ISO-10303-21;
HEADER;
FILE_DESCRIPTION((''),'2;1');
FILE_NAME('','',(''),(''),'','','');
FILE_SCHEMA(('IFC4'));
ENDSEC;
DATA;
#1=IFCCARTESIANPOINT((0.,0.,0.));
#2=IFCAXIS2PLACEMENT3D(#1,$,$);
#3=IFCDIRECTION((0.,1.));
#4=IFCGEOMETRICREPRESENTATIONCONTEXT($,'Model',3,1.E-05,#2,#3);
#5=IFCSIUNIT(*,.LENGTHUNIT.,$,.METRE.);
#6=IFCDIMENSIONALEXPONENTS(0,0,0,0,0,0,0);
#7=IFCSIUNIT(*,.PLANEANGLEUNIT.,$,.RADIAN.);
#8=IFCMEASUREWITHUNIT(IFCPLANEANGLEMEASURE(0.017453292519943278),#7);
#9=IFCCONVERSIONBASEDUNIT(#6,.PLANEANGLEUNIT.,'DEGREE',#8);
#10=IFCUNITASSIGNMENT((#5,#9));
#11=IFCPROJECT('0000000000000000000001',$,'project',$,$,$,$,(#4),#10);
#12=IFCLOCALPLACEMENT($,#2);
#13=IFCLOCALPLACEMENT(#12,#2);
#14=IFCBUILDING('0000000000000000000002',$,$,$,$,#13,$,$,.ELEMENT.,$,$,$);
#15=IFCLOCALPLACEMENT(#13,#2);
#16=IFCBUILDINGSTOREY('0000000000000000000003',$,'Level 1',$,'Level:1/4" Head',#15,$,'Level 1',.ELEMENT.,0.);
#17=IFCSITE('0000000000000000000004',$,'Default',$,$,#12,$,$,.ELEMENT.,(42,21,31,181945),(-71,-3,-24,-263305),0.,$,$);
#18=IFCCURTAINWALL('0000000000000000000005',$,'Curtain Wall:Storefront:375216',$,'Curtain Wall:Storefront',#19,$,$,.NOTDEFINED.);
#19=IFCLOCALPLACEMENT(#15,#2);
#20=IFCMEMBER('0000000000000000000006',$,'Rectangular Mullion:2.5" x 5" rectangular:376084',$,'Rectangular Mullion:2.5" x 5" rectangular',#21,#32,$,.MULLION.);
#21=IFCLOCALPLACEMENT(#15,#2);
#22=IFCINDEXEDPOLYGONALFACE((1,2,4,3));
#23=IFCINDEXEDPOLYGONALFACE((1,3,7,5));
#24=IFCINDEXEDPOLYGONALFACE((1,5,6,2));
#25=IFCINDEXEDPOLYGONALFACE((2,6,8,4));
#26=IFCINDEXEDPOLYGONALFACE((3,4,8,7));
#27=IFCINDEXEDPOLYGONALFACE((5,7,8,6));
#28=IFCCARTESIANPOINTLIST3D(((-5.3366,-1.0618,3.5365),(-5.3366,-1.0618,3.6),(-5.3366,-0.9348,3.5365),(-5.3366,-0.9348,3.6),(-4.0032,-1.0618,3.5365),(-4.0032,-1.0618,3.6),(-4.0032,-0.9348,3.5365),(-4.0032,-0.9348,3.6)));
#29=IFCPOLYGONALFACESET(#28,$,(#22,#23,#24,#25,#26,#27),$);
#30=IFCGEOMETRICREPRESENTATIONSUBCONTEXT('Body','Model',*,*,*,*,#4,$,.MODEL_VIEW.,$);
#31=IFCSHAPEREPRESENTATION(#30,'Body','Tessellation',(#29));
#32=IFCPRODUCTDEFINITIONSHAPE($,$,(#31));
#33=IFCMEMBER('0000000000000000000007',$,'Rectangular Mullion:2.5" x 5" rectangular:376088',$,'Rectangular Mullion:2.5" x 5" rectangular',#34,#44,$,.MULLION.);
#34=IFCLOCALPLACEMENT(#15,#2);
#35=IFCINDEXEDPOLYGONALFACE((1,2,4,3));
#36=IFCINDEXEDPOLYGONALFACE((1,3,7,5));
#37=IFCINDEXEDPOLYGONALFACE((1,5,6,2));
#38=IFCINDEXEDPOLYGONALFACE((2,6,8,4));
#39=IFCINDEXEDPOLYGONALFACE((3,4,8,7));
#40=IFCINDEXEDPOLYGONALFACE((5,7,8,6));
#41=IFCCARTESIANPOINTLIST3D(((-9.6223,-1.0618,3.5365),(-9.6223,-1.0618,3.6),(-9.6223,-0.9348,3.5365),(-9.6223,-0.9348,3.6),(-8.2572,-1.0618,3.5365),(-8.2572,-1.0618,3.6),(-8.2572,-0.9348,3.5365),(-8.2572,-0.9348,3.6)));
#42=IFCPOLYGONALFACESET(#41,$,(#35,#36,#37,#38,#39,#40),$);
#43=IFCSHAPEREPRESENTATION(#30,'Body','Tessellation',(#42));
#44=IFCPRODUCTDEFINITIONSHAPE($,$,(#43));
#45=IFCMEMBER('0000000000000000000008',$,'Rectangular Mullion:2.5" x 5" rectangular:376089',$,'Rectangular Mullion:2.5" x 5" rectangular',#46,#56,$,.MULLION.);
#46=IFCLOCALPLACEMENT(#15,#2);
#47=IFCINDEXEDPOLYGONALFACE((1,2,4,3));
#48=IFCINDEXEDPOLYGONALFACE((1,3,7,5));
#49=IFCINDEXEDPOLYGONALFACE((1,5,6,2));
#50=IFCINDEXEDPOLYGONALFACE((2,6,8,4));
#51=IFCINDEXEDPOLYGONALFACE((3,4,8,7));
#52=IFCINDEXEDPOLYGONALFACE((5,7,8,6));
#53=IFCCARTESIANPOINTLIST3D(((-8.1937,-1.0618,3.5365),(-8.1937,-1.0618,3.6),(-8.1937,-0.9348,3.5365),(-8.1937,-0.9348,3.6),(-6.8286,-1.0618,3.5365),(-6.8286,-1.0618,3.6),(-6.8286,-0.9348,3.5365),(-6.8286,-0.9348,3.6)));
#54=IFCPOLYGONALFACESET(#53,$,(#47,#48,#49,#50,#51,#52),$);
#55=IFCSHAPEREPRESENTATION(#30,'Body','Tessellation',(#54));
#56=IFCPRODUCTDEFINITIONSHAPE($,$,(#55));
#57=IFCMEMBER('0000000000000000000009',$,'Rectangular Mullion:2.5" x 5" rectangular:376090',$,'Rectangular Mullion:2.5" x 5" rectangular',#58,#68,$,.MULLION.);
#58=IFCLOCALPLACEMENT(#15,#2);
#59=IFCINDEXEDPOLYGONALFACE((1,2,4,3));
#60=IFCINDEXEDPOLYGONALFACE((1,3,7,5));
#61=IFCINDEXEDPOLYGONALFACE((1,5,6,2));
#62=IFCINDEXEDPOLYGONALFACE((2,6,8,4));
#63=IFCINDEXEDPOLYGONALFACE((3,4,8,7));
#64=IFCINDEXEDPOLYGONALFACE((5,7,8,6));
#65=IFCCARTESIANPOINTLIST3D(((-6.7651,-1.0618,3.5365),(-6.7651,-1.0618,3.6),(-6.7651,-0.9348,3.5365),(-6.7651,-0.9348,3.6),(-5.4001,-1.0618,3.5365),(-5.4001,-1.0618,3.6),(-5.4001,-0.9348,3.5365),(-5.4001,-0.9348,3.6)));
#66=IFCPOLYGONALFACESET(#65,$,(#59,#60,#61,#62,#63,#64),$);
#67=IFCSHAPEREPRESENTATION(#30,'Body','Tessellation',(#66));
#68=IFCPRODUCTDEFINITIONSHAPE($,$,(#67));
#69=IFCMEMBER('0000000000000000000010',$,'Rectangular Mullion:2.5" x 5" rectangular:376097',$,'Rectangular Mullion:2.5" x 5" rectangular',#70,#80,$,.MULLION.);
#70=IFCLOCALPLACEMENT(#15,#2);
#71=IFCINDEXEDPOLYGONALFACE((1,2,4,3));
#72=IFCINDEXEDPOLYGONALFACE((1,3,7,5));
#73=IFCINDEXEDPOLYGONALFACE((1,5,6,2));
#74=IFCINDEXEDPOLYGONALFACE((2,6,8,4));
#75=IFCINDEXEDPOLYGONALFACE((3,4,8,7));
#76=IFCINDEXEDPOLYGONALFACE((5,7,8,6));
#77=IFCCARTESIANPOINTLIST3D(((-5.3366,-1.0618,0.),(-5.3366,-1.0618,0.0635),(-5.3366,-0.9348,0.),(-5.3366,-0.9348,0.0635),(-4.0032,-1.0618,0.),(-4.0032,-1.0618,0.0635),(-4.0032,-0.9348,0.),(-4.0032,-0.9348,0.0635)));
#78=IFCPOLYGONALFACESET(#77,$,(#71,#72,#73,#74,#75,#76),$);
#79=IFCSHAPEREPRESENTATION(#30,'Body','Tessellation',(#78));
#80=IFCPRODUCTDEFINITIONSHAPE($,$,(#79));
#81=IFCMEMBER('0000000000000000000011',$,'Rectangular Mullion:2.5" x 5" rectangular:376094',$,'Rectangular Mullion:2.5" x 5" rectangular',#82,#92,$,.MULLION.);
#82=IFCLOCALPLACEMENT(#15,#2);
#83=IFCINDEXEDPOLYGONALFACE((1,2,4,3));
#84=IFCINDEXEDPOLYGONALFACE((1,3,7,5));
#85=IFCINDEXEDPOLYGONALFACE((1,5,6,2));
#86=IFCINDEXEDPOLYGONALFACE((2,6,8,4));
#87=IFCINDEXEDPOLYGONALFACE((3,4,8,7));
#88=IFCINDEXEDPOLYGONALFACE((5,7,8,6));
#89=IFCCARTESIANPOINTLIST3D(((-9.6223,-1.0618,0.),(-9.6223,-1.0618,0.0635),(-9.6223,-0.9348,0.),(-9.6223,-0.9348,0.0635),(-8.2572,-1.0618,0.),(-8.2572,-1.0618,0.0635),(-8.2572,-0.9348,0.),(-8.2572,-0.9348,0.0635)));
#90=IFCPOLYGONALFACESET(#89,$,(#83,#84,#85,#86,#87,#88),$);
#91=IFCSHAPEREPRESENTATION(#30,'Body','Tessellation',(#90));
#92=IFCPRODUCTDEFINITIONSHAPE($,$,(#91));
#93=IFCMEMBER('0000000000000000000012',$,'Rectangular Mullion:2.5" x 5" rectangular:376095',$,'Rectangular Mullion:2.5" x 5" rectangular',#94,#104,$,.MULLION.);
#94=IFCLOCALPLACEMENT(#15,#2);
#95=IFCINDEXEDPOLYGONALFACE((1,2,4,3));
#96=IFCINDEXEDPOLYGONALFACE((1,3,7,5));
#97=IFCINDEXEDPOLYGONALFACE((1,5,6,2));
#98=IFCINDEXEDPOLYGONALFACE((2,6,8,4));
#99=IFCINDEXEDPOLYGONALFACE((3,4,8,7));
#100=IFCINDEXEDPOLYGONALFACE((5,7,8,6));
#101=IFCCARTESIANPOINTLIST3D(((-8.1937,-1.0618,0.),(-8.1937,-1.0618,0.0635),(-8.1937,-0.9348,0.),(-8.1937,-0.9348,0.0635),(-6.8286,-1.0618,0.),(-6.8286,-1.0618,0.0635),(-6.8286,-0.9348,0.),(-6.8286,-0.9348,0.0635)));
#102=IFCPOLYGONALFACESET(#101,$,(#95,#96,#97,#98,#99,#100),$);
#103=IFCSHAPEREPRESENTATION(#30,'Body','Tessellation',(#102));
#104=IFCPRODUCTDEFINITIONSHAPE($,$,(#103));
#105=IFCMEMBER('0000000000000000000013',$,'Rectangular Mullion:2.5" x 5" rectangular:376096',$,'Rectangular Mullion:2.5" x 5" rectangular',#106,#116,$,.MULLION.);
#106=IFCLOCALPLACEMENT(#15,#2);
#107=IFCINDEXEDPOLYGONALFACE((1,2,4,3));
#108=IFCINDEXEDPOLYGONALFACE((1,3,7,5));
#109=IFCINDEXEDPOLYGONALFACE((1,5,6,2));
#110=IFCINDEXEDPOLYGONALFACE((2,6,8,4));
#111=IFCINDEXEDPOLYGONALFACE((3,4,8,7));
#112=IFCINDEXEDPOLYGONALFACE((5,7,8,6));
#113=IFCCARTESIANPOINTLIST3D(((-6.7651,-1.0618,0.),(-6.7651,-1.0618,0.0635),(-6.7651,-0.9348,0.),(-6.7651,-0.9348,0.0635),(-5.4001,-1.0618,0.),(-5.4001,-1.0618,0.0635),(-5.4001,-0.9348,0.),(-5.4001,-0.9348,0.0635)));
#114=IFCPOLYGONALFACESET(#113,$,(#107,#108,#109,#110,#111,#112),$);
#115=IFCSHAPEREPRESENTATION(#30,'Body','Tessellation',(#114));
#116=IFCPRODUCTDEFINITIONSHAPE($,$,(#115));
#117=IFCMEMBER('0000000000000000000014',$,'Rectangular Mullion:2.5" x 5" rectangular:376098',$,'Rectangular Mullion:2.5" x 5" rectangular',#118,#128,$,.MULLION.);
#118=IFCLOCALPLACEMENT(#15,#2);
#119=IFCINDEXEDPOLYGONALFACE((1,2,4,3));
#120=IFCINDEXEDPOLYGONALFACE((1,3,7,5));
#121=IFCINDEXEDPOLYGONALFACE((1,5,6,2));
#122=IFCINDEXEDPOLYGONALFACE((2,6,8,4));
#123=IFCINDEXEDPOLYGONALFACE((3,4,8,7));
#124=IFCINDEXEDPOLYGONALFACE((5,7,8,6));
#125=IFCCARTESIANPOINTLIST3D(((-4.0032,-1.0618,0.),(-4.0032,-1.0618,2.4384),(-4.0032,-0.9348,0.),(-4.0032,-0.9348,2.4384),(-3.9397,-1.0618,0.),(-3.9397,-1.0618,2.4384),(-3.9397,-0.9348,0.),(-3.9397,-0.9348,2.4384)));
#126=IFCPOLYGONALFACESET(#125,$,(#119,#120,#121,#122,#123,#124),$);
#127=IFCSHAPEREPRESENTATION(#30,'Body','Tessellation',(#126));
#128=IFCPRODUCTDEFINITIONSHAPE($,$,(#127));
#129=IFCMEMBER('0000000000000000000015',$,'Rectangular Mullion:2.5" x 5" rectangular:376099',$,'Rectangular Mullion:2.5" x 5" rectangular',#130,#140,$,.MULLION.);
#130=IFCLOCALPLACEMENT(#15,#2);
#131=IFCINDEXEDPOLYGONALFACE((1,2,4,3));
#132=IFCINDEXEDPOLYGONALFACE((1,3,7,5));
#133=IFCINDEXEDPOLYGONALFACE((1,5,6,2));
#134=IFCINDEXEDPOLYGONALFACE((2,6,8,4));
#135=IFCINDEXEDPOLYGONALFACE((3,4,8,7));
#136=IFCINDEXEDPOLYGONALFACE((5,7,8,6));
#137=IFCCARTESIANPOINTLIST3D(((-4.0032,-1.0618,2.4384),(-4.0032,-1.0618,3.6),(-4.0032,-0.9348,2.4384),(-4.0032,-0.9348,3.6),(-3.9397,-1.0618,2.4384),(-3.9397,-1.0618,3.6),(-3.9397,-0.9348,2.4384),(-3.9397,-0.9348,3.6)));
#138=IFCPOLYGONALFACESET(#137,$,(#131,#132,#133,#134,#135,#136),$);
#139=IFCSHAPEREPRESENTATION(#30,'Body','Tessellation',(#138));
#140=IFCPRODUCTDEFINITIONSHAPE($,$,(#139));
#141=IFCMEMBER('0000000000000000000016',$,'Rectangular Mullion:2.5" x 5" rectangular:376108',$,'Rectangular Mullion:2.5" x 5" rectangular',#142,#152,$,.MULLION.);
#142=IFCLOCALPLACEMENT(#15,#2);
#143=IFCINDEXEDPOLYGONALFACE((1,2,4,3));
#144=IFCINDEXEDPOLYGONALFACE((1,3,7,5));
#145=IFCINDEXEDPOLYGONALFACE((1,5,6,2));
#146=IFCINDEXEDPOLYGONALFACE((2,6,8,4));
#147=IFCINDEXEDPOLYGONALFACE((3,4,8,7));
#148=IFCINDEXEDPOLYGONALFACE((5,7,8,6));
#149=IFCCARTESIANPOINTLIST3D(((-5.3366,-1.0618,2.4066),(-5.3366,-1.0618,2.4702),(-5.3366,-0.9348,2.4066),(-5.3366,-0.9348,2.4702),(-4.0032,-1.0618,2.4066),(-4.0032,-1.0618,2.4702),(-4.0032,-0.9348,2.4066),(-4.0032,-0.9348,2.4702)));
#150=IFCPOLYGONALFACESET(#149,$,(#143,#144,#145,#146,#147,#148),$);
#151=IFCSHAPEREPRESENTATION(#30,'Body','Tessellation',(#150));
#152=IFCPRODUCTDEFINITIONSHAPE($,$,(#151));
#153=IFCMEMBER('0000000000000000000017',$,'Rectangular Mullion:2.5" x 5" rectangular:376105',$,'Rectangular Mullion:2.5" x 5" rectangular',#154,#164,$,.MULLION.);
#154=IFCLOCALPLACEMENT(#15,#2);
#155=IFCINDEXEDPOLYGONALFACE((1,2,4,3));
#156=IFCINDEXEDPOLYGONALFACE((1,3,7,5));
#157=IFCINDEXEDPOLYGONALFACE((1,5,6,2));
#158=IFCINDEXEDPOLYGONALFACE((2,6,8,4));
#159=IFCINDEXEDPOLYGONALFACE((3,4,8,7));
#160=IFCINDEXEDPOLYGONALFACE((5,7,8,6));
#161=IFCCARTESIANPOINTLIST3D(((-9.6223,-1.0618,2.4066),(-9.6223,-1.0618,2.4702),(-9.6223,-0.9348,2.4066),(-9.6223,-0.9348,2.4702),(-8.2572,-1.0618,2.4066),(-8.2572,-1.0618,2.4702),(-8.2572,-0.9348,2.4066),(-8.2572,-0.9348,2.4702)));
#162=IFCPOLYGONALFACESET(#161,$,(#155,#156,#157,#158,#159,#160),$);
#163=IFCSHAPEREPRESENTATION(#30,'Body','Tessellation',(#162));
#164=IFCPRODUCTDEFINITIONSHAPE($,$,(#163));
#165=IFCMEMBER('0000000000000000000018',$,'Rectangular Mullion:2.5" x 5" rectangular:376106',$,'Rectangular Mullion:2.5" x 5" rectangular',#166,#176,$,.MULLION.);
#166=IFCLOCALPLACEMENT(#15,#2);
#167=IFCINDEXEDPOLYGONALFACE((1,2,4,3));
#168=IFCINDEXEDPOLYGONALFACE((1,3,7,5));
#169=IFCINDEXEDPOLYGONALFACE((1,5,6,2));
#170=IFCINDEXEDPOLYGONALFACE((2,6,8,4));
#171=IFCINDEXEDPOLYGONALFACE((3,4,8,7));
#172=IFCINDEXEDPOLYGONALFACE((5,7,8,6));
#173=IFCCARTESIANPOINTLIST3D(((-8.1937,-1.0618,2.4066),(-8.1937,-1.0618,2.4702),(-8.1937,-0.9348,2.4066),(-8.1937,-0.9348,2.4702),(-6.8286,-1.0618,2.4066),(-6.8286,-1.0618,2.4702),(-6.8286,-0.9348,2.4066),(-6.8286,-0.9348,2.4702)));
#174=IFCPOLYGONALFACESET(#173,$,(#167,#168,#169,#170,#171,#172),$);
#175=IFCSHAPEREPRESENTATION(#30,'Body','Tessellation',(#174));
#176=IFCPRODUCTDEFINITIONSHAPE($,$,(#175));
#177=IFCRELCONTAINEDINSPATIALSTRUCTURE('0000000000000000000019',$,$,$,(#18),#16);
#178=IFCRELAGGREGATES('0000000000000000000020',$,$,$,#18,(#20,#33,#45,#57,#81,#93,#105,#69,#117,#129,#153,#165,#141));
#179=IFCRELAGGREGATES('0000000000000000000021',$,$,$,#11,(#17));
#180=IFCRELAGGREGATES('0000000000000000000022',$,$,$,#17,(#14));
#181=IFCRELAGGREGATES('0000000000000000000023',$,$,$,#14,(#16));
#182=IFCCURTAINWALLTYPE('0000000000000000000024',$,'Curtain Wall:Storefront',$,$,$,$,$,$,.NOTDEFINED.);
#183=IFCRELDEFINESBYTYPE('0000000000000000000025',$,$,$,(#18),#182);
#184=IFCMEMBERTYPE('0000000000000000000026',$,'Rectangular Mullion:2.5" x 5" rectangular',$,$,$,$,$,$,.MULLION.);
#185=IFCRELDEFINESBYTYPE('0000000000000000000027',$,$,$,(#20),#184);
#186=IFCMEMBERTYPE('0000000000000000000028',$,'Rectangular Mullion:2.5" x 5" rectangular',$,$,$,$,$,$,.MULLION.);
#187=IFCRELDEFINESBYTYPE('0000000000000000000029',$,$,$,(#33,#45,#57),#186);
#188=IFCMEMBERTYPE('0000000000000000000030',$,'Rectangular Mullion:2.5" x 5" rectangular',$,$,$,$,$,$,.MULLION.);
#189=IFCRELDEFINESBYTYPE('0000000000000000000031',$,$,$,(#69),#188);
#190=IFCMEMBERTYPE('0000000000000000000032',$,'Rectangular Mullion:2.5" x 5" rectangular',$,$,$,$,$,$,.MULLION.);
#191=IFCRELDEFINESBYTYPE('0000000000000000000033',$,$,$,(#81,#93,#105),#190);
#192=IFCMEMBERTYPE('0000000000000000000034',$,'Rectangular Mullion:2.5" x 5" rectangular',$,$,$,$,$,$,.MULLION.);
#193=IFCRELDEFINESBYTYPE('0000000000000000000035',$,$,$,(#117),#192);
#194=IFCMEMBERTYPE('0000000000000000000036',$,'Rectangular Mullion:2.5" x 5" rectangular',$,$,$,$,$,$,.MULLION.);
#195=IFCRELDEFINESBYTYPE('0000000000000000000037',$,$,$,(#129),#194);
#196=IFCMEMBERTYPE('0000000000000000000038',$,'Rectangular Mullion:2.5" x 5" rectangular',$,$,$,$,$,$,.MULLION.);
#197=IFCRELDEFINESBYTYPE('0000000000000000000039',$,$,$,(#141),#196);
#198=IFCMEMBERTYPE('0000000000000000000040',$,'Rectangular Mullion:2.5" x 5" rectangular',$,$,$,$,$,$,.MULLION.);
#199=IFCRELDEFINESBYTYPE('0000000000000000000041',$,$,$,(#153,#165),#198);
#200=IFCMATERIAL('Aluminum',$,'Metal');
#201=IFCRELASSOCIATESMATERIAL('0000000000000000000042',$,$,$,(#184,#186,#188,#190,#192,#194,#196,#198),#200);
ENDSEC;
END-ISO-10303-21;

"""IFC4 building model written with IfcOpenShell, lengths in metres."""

from ifc_helpers import new_model, entity, si_unit, converted_unit, direction, frame, frame_2d, origin, origin_2d_with_axis, place, context, subcontext, project, spatial, rectangle, extrude, source, transform, mapped, material, material_profile, profile_set, type_object, type_shapes, element, aggregate, save


model = new_model("IFC4")

# Units and contexts
model_context = context("Model", 3, precision=1e-05, world=origin(), true_north=direction((0.0, 1.0)))
body_context = subcontext(model_context, "Body", "Model", "MODEL_VIEW")
ifc_project = project(units=[si_unit("LENGTHUNIT", "METRE"), converted_unit("PLANEANGLEUNIT", "DEGREE", entity("IfcPlaneAngleMeasure", 0.017453292519943278), si_unit("PLANEANGLEUNIT", "RADIAN"), dimensions=[0, 0, 0, 0, 0, 0, 0])], contexts=[model_context])

# Site, building, storey
site_placement = place(None, origin())
site = spatial("IfcSite", under=ifc_project, at=site_placement, Name="Default", CompositionType="ELEMENT", RefLatitude=(42, 21, 31, 181945), RefLongitude=(-71, -3, -24, -263305), RefElevation=0.0)
building_placement = place(site_placement, origin())
building = spatial("IfcBuilding", under=site, at=building_placement, CompositionType="ELEMENT")
storey_placement = place(building_placement, origin())
storey = spatial("IfcBuildingStorey", under=building, at=storey_placement, Name="Level 1", ObjectType="Level:1/4\" Head", LongName="Level 1", CompositionType="ELEMENT", Elevation=0.0)

# Curtain wall, members
curtain_wall_type = type_object("IfcCurtainWallType", Name="Curtain Wall:Storefront", PredefinedType="NOTDEFINED")
curtain_wall_placement = place(storey_placement, origin())
curtain_wall = element("IfcCurtainWall", 1, at=curtain_wall_placement, inside=storey, type_object=curtain_wall_type, Name="Curtain Wall:Storefront:375216", ObjectType="Curtain Wall:Storefront", PredefinedType="NOTDEFINED")
ifc_material_1 = material(Name="Aluminum", Category="Metal")
ifc_material_profile = material_profile(ifc_material_1, rectangle(XDim=0.0635, YDim=0.127, at=frame_2d((0.0, 0.0), x_axis=(1.0, 0.0))), Name="2.5\" x 5\" rectangular")
ifc_profile_set = profile_set([ifc_material_profile], Name="2.5\" x 5\" rectangular")
member_type_1 = type_object("IfcMemberType", Name="Rectangular Mullion:2.5\" x 5\" rectangular", PredefinedType="MULLION", material=ifc_profile_set)
shared_shape_1 = source(origin(), body_context, "Body", "SweptSolid", [
    extrude(rectangle(XDim=0.0635, YDim=0.127, at=frame_2d((0.0, 0.0), x_axis=(1.0, 0.0))), frame((-0.0318, 0.0, -1.3333), z_axis=(0.0, 0.0, 1.0), x_axis=(-1.0, 0.0, 0.0)), (0.0, 0.0, 1.0), 1.3333),
])
type_shapes(member_type_1, [shared_shape_1])
member_1_placement = place(curtain_wall_placement, frame((-4.0032, -0.9983, 3.6), z_axis=(1.0, 0.0, 0.0), x_axis=(0.0, 0.0, 1.0)))
member_1 = element("IfcMember", 2, at=member_1_placement, type_object=member_type_1, Name="Rectangular Mullion:2.5\" x 5\" rectangular:376084", ObjectType="Rectangular Mullion:2.5\" x 5\" rectangular", PredefinedType="MULLION", context=body_context, shape_type="MappedRepresentation", body=[
    mapped(shared_shape_1, transform((0.0, 0.0, 0.0), scale=1.0)),
])
member_type_2 = type_object("IfcMemberType", Name="Rectangular Mullion:2.5\" x 5\" rectangular", PredefinedType="MULLION", material=ifc_profile_set)
shared_shape_2 = source(origin(), body_context, "Body", "SweptSolid", [
    extrude(rectangle(XDim=0.0635, YDim=0.127, at=frame_2d((0.0, 0.0), x_axis=(1.0, 0.0))), frame((-0.0318, 0.0, -1.3651), z_axis=(0.0, 0.0, 1.0), x_axis=(-1.0, 0.0, 0.0)), (0.0, 0.0, 1.0), 1.3651),
])
type_shapes(member_type_2, [shared_shape_2])
member_2_placement = place(curtain_wall_placement, frame((-8.2572, -0.9983, 3.6), z_axis=(1.0, 0.0, 0.0), x_axis=(0.0, 0.0, 1.0)))
member_2 = element("IfcMember", 3, at=member_2_placement, type_object=member_type_2, Name="Rectangular Mullion:2.5\" x 5\" rectangular:376088", ObjectType="Rectangular Mullion:2.5\" x 5\" rectangular", PredefinedType="MULLION", context=body_context, shape_type="MappedRepresentation", body=[
    mapped(shared_shape_2, transform((0.0, 0.0, 0.0), scale=1.0)),
])
member_3_placement = place(curtain_wall_placement, frame((-6.8286, -0.9983, 3.6), z_axis=(1.0, 0.0, 0.0), x_axis=(0.0, 0.0, 1.0)))
member_3 = element("IfcMember", 4, at=member_3_placement, type_object=member_type_2, Name="Rectangular Mullion:2.5\" x 5\" rectangular:376089", ObjectType="Rectangular Mullion:2.5\" x 5\" rectangular", PredefinedType="MULLION", context=body_context, shape_type="MappedRepresentation", body=[
    mapped(shared_shape_2, transform((0.0, 0.0, 0.0), scale=1.0)),
])
member_4_placement = place(curtain_wall_placement, frame((-5.4001, -0.9983, 3.6), z_axis=(1.0, 0.0, 0.0), x_axis=(0.0, 0.0, 1.0)))
member_4 = element("IfcMember", 5, at=member_4_placement, type_object=member_type_2, Name="Rectangular Mullion:2.5\" x 5\" rectangular:376090", ObjectType="Rectangular Mullion:2.5\" x 5\" rectangular", PredefinedType="MULLION", context=body_context, shape_type="MappedRepresentation", body=[
    mapped(shared_shape_2, transform((0.0, 0.0, 0.0), scale=1.0)),
])
member_type_3 = type_object("IfcMemberType", Name="Rectangular Mullion:2.5\" x 5\" rectangular", PredefinedType="MULLION", material=ifc_profile_set)
shared_shape_3 = source(origin(), body_context, "Body", "SweptSolid", [
    extrude(rectangle(XDim=0.0635, YDim=0.127, at=frame_2d((0.0, 0.0), x_axis=(1.0, 0.0))), frame((-0.0318, 0.0, -1.3333), z_axis=(0.0, 0.0, 1.0), x_axis=(-1.0, 0.0, 0.0)), (0.0, 0.0, 1.0), 1.3333),
])
type_shapes(member_type_3, [shared_shape_3])
member_5_placement = place(curtain_wall_placement, frame((-5.3366, -0.9983, 0.0), z_axis=(-1.0, 0.0, 0.0), x_axis=(0.0, 0.0, -1.0)))
member_5 = element("IfcMember", 6, at=member_5_placement, type_object=member_type_3, Name="Rectangular Mullion:2.5\" x 5\" rectangular:376097", ObjectType="Rectangular Mullion:2.5\" x 5\" rectangular", PredefinedType="MULLION", context=body_context, shape_type="MappedRepresentation", body=[
    mapped(shared_shape_3, transform((0.0, 0.0, 0.0), scale=1.0)),
])
member_type_4 = type_object("IfcMemberType", Name="Rectangular Mullion:2.5\" x 5\" rectangular", PredefinedType="MULLION", material=ifc_profile_set)
shared_shape_4 = source(origin(), body_context, "Body", "SweptSolid", [
    extrude(rectangle(XDim=0.0635, YDim=0.127, at=frame_2d((0.0, 0.0), x_axis=(1.0, 0.0))), frame((-0.0318, 0.0, -1.3651), z_axis=(0.0, 0.0, 1.0), x_axis=(-1.0, 0.0, 0.0)), (0.0, 0.0, 1.0), 1.3651),
])
type_shapes(member_type_4, [shared_shape_4])
member_6_placement = place(curtain_wall_placement, frame((-9.6223, -0.9983, 0.0), z_axis=(-1.0, 0.0, 0.0), x_axis=(0.0, 0.0, -1.0)))
member_6 = element("IfcMember", 7, at=member_6_placement, type_object=member_type_4, Name="Rectangular Mullion:2.5\" x 5\" rectangular:376094", ObjectType="Rectangular Mullion:2.5\" x 5\" rectangular", PredefinedType="MULLION", context=body_context, shape_type="MappedRepresentation", body=[
    mapped(shared_shape_4, transform((0.0, 0.0, 0.0), scale=1.0)),
])
member_7_placement = place(curtain_wall_placement, frame((-8.1937, -0.9983, 0.0), z_axis=(-1.0, 0.0, 0.0), x_axis=(0.0, 0.0, -1.0)))
member_7 = element("IfcMember", 8, at=member_7_placement, type_object=member_type_4, Name="Rectangular Mullion:2.5\" x 5\" rectangular:376095", ObjectType="Rectangular Mullion:2.5\" x 5\" rectangular", PredefinedType="MULLION", context=body_context, shape_type="MappedRepresentation", body=[
    mapped(shared_shape_4, transform((0.0, 0.0, 0.0), scale=1.0)),
])
member_8_placement = place(curtain_wall_placement, frame((-6.7651, -0.9983, 0.0), z_axis=(-1.0, 0.0, 0.0), x_axis=(0.0, 0.0, -1.0)))
member_8 = element("IfcMember", 9, at=member_8_placement, type_object=member_type_4, Name="Rectangular Mullion:2.5\" x 5\" rectangular:376096", ObjectType="Rectangular Mullion:2.5\" x 5\" rectangular", PredefinedType="MULLION", context=body_context, shape_type="MappedRepresentation", body=[
    mapped(shared_shape_4, transform((0.0, 0.0, 0.0), scale=1.0)),
])
member_type_5 = type_object("IfcMemberType", Name="Rectangular Mullion:2.5\" x 5\" rectangular", PredefinedType="MULLION", material=ifc_profile_set)
shared_shape_5 = source(origin(), body_context, "Body", "SweptSolid", [
    extrude(rectangle(XDim=0.0635, YDim=0.127, at=origin_2d_with_axis()), frame((-0.0318, 0.0, -2.4384), z_axis=(0.0, 0.0, 1.0), x_axis=(-1.0, 0.0, 0.0)), (0.0, 0.0, 1.0), 2.4384),
])
type_shapes(member_type_5, [shared_shape_5])
member_9_placement = place(curtain_wall_placement, frame((-3.9397, -0.9983, 0.0), z_axis=(0.0, 0.0, -1.0), x_axis=(1.0, 0.0, 0.0)))
member_9 = element("IfcMember", 10, at=member_9_placement, type_object=member_type_5, Name="Rectangular Mullion:2.5\" x 5\" rectangular:376098", ObjectType="Rectangular Mullion:2.5\" x 5\" rectangular", PredefinedType="MULLION", context=body_context, shape_type="MappedRepresentation", body=[
    mapped(shared_shape_5, transform((0.0, 0.0, 0.0), scale=1.0)),
])
member_type_6 = type_object("IfcMemberType", Name="Rectangular Mullion:2.5\" x 5\" rectangular", PredefinedType="MULLION", material=ifc_profile_set)
shared_shape_6 = source(origin(), body_context, "Body", "SweptSolid", [
    extrude(rectangle(XDim=0.0635, YDim=0.127, at=origin_2d_with_axis()), frame((-0.0318, 0.0, -1.1616), z_axis=(0.0, 0.0, 1.0), x_axis=(-1.0, 0.0, 0.0)), (0.0, 0.0, 1.0), 1.1616),
])
type_shapes(member_type_6, [shared_shape_6])
member_10_placement = place(curtain_wall_placement, frame((-3.9397, -0.9983, 2.4384), z_axis=(0.0, 0.0, -1.0), x_axis=(1.0, 0.0, 0.0)))
member_10 = element("IfcMember", 11, at=member_10_placement, type_object=member_type_6, Name="Rectangular Mullion:2.5\" x 5\" rectangular:376099", ObjectType="Rectangular Mullion:2.5\" x 5\" rectangular", PredefinedType="MULLION", context=body_context, shape_type="MappedRepresentation", body=[
    mapped(shared_shape_6, transform((0.0, 0.0, 0.0), scale=1.0)),
])
member_type_7 = type_object("IfcMemberType", Name="Rectangular Mullion:2.5\" x 5\" rectangular", PredefinedType="MULLION", material=ifc_profile_set)
shared_shape_7 = source(origin(), body_context, "Body", "SweptSolid", [
    extrude(rectangle(XDim=0.0635, YDim=0.127, at=origin_2d_with_axis()), frame((0.0, 0.0, -1.3333), z_axis=(0.0, 0.0, 1.0), x_axis=(-1.0, 0.0, 0.0)), (0.0, 0.0, 1.0), 1.3333),
])
type_shapes(member_type_7, [shared_shape_7])
member_11_placement = place(curtain_wall_placement, frame((-4.0032, -0.9983, 2.4384), z_axis=(1.0, 0.0, 0.0), x_axis=(0.0, 0.0, 1.0)))
member_11 = element("IfcMember", 12, at=member_11_placement, type_object=member_type_7, Name="Rectangular Mullion:2.5\" x 5\" rectangular:376108", ObjectType="Rectangular Mullion:2.5\" x 5\" rectangular", PredefinedType="MULLION", context=body_context, shape_type="MappedRepresentation", body=[
    mapped(shared_shape_7, transform((0.0, 0.0, 0.0), scale=1.0)),
])
member_type_8 = type_object("IfcMemberType", Name="Rectangular Mullion:2.5\" x 5\" rectangular", PredefinedType="MULLION", material=ifc_profile_set)
shared_shape_8 = source(origin(), body_context, "Body", "SweptSolid", [
    extrude(rectangle(XDim=0.0635, YDim=0.127, at=origin_2d_with_axis()), frame((0.0, 0.0, -1.3651), z_axis=(0.0, 0.0, 1.0), x_axis=(-1.0, 0.0, 0.0)), (0.0, 0.0, 1.0), 1.3651),
])
type_shapes(member_type_8, [shared_shape_8])
member_12_placement = place(curtain_wall_placement, frame((-8.2572, -0.9983, 2.4384), z_axis=(1.0, 0.0, 0.0), x_axis=(0.0, 0.0, 1.0)))
member_12 = element("IfcMember", 13, at=member_12_placement, type_object=member_type_8, Name="Rectangular Mullion:2.5\" x 5\" rectangular:376105", ObjectType="Rectangular Mullion:2.5\" x 5\" rectangular", PredefinedType="MULLION", context=body_context, shape_type="MappedRepresentation", body=[
    mapped(shared_shape_8, transform((0.0, 0.0, 0.0), scale=1.0)),
])
member_13_placement = place(curtain_wall_placement, frame((-6.8286, -0.9983, 2.4384), z_axis=(1.0, 0.0, 0.0), x_axis=(0.0, 0.0, 1.0)))
member_13 = element("IfcMember", 14, at=member_13_placement, type_object=member_type_8, Name="Rectangular Mullion:2.5\" x 5\" rectangular:376106", ObjectType="Rectangular Mullion:2.5\" x 5\" rectangular", PredefinedType="MULLION", context=body_context, shape_type="MappedRepresentation", body=[
    mapped(shared_shape_8, transform((0.0, 0.0, 0.0), scale=1.0)),
])
aggregate(curtain_wall, [member_1, member_2, member_3, member_4, member_6, member_7, member_8, member_5, member_9, member_10, member_12, member_13, member_11])

save(model, "model.ifc")
